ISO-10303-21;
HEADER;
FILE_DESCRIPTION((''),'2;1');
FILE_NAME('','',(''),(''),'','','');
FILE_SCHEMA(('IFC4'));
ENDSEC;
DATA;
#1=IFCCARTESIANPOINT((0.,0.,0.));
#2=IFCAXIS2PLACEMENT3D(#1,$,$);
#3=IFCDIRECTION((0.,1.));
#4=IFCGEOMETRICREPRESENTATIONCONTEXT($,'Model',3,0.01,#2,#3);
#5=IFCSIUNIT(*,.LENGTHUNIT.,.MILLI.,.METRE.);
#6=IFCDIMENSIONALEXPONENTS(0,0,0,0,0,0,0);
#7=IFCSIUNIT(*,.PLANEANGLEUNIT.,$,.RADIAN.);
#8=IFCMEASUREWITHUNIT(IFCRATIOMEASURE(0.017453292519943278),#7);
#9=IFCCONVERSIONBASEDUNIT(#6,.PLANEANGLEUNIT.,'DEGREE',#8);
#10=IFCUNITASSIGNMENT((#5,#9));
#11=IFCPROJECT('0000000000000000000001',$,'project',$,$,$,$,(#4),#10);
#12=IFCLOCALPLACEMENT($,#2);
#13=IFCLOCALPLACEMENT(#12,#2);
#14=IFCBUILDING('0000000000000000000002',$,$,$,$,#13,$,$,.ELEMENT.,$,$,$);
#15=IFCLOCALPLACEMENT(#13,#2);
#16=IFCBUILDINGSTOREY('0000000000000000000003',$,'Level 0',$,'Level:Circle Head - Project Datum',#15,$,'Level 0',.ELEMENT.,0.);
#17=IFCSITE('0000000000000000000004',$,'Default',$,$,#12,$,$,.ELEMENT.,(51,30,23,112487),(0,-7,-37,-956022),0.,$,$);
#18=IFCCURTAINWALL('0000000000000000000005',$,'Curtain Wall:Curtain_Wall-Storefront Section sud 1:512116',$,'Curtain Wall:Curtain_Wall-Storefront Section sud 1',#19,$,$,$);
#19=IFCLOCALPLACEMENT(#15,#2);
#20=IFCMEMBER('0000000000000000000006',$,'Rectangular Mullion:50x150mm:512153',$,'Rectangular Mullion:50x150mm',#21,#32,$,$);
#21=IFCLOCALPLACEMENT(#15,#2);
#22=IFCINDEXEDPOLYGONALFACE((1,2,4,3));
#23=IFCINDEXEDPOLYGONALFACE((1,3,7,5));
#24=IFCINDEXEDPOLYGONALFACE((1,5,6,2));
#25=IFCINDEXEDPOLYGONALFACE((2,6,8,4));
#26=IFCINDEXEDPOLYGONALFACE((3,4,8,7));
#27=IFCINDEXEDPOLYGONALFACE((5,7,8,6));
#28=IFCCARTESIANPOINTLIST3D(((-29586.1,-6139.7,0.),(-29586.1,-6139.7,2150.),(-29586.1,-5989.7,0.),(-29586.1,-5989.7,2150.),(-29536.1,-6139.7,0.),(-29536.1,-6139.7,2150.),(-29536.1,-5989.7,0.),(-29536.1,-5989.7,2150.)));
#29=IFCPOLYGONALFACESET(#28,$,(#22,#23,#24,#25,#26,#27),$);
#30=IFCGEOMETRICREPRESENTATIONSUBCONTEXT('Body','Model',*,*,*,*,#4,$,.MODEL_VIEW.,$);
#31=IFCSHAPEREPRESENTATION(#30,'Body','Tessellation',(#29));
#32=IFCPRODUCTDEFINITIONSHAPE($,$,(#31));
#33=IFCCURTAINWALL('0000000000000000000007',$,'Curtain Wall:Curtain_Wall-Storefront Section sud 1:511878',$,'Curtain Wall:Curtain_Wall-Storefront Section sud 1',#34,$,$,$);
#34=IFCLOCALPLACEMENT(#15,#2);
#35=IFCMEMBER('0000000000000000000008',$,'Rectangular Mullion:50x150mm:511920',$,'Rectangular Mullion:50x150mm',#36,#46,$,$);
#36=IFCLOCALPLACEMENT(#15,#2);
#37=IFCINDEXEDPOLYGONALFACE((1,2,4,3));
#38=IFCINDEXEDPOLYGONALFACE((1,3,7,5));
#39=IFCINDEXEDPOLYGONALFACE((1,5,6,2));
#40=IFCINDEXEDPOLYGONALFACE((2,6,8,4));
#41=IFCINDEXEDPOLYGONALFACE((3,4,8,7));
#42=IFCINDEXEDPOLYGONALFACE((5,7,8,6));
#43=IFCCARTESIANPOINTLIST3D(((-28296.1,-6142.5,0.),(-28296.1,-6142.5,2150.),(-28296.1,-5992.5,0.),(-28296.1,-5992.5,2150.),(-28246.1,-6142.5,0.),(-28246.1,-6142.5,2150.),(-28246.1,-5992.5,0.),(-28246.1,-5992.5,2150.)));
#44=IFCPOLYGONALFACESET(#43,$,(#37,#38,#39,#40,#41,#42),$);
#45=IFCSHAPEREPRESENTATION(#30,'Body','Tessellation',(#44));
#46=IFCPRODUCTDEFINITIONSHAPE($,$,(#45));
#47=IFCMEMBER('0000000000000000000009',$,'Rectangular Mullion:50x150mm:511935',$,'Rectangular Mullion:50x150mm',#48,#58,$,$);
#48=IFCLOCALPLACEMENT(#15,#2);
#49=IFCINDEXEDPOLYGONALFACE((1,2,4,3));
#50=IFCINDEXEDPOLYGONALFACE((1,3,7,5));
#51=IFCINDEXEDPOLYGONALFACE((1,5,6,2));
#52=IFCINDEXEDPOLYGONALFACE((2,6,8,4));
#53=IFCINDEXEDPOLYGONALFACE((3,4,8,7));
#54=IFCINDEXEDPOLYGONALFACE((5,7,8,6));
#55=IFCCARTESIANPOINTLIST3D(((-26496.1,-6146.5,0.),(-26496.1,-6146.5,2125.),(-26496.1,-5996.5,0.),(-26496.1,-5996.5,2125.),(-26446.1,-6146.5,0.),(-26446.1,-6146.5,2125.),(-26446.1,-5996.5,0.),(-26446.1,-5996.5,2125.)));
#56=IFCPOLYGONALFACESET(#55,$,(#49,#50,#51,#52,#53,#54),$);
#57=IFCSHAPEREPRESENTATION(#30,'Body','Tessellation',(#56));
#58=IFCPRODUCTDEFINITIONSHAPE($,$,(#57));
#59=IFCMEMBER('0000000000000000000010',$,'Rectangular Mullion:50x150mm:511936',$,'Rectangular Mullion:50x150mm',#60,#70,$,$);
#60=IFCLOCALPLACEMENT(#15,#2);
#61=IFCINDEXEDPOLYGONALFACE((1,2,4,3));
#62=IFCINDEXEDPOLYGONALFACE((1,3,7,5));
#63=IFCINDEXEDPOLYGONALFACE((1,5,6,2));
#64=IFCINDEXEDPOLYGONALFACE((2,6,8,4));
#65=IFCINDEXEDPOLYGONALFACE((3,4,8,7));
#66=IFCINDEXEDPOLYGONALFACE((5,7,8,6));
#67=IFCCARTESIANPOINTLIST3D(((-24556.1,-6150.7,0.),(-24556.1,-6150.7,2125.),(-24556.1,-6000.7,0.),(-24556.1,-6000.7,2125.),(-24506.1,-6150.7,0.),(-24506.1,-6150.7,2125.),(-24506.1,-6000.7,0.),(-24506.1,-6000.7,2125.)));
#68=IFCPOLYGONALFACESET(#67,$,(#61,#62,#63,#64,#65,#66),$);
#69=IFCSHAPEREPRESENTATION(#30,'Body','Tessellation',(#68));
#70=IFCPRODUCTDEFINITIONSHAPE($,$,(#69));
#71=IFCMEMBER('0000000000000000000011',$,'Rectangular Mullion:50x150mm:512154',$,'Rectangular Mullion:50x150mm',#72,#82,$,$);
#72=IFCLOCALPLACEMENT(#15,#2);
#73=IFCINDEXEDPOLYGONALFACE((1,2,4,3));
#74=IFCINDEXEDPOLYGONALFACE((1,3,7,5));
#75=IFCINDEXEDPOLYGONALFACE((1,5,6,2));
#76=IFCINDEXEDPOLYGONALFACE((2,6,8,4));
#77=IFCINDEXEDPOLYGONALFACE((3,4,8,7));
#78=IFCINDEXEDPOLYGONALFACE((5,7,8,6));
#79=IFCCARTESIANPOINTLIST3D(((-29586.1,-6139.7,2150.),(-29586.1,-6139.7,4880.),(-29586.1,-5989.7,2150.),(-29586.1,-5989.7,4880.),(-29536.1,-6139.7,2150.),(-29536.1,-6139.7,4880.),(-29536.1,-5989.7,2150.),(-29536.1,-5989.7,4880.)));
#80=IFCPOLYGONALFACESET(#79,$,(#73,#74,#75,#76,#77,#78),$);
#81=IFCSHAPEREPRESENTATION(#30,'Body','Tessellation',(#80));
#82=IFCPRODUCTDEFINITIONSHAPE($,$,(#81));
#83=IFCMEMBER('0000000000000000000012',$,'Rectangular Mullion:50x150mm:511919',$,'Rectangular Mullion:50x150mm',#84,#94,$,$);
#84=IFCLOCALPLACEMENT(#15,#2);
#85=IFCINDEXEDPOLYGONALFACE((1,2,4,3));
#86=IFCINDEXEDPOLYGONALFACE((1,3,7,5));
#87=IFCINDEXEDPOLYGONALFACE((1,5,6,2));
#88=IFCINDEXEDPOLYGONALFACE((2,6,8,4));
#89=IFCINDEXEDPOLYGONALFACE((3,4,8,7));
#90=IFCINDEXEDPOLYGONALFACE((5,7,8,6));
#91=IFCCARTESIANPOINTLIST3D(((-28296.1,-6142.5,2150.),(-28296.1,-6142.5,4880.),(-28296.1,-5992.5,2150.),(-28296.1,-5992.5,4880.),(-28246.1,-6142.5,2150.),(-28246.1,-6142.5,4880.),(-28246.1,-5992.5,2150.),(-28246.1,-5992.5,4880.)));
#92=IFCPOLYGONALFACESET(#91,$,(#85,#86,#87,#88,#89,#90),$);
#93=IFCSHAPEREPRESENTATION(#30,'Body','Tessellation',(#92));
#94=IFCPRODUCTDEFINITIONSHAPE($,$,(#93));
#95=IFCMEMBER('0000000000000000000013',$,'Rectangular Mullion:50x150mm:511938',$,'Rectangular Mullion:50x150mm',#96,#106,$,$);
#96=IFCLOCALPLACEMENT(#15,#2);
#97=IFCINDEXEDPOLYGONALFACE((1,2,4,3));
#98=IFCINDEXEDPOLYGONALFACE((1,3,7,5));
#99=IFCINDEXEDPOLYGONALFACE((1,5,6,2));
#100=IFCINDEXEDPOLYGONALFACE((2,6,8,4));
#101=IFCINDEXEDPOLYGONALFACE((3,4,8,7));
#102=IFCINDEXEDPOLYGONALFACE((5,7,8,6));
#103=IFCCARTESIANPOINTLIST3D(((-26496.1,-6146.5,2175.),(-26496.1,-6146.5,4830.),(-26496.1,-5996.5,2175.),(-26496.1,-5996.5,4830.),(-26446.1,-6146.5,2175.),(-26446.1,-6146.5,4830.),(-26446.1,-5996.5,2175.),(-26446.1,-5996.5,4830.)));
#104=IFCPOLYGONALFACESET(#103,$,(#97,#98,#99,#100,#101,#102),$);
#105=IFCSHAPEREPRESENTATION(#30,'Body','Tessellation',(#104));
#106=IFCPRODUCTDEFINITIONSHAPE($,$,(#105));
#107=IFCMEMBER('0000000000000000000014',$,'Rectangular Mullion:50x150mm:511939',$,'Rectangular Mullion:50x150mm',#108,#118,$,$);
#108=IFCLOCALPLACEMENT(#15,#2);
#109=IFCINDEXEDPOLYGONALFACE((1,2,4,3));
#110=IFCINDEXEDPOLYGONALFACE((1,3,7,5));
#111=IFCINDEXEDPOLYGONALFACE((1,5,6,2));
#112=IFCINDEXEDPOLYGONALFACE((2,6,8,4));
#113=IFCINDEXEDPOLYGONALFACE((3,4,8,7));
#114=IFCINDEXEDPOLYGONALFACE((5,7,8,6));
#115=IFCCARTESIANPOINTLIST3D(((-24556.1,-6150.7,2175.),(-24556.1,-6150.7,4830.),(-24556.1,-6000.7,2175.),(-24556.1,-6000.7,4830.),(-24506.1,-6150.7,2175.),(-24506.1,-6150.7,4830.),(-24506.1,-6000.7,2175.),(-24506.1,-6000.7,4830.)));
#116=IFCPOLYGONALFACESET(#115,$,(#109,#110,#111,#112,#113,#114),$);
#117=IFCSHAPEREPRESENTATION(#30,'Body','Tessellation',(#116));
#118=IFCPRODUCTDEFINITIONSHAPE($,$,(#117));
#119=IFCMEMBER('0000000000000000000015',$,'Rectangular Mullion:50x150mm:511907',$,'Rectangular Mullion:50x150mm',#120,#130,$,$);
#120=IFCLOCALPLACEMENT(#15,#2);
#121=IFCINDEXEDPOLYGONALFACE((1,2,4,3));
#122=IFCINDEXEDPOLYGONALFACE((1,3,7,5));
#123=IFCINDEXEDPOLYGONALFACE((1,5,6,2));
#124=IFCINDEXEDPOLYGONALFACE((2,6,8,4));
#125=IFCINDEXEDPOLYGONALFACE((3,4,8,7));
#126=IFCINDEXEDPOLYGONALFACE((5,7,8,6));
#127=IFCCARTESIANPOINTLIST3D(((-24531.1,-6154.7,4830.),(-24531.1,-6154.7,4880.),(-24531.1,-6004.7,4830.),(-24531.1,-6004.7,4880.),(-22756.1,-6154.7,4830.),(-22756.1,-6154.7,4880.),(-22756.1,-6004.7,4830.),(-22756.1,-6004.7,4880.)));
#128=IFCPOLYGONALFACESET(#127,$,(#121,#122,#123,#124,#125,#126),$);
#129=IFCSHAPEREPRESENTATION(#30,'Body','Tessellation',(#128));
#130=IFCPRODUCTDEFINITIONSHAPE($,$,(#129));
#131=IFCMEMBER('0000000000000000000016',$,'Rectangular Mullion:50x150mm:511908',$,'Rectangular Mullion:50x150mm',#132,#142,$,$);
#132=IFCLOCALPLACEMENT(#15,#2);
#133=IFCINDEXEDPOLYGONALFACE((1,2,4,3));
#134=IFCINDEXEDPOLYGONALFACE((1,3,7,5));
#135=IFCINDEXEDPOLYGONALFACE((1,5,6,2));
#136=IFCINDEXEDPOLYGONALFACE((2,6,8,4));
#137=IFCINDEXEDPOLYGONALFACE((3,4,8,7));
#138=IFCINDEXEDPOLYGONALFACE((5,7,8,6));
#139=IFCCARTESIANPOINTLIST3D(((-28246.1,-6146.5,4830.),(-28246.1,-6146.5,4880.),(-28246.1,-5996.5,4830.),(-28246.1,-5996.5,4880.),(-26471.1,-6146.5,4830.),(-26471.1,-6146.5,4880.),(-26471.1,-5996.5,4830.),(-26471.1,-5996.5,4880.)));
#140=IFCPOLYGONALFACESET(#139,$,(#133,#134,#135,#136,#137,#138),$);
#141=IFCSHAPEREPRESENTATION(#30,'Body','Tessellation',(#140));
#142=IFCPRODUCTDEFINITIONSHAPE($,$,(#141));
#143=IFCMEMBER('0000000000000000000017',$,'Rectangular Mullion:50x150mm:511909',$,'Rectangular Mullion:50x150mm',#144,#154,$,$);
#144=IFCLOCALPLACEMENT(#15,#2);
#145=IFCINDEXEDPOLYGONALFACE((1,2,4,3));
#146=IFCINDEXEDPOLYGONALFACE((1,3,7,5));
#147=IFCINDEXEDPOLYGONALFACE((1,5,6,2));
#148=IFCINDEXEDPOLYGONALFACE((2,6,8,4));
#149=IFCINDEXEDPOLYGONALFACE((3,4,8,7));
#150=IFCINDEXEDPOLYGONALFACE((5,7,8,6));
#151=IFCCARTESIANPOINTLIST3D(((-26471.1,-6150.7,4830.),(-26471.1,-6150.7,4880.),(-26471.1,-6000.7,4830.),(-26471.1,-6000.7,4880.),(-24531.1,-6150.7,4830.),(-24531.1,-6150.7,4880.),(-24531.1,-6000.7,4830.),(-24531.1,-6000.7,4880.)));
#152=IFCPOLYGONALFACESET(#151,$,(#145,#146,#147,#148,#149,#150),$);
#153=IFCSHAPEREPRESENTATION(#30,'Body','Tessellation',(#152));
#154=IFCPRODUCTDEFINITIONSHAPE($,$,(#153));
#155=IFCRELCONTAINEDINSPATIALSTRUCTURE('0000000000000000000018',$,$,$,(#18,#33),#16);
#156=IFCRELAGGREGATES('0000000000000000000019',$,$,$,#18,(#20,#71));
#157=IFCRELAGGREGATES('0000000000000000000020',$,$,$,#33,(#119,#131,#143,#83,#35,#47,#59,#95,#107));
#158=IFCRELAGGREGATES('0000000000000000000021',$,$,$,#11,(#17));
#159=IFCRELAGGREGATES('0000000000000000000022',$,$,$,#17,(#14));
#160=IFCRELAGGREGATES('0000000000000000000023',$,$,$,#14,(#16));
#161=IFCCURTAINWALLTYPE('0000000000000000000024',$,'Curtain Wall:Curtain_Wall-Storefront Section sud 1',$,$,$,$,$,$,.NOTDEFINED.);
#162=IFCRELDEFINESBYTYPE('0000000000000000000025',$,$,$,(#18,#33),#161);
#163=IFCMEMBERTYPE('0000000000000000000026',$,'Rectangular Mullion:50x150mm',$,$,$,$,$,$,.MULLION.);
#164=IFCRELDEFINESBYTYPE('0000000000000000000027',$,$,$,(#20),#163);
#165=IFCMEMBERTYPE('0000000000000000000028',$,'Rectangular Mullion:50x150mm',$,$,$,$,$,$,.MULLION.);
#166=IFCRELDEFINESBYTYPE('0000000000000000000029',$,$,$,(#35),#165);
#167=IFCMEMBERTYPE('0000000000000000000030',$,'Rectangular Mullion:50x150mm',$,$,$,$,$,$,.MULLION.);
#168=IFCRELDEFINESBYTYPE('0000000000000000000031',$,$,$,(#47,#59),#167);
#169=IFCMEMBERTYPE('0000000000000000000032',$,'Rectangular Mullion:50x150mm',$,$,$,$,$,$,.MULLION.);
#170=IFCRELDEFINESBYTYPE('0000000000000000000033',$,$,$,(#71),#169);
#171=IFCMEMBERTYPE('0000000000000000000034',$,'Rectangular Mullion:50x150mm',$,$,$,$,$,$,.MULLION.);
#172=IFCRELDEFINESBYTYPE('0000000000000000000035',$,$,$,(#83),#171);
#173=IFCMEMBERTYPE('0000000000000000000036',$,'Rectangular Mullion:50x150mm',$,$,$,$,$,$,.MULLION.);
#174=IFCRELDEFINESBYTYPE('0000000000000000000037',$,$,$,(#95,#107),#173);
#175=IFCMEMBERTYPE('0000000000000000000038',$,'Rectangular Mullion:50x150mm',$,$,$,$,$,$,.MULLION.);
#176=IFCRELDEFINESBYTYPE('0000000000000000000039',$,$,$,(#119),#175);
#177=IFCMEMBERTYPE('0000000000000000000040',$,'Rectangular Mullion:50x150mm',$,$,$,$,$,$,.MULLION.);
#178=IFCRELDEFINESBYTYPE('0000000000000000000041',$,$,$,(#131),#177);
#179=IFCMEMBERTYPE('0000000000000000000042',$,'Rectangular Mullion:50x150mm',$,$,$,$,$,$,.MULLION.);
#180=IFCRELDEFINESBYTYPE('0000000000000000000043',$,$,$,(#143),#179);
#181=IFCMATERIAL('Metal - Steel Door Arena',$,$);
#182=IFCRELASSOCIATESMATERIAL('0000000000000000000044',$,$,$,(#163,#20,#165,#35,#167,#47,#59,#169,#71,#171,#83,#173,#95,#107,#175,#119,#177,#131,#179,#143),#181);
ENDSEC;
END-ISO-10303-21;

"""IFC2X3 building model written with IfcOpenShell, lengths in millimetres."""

from ifc_helpers import new_model, entity, si_unit, converted_unit, direction, frame, origin, origin_2d_with_axis, place, context, subcontext, project, spatial, rectangle, extrude, source, transform, mapped, material, type_object, type_shapes, element, aggregate, save


model = new_model("IFC2X3")

# Units and contexts
model_context = context("Model", 3, precision=0.01, world=origin(), true_north=direction((0.0, 1.0)))
body_context = subcontext(model_context, "Body", "Model", "MODEL_VIEW")
ifc_project = project(units=[si_unit("LENGTHUNIT", "METRE", prefix="MILLI"), converted_unit("PLANEANGLEUNIT", "DEGREE", entity("IfcRatioMeasure", 0.017453292519943278), si_unit("PLANEANGLEUNIT", "RADIAN"), dimensions=[0, 0, 0, 0, 0, 0, 0])], contexts=[model_context])

# Site, building, storey
site_placement = place(None, origin())
site = spatial("IfcSite", under=ifc_project, at=site_placement, Name="Default", CompositionType="ELEMENT", RefLatitude=(51, 30, 23, 112487), RefLongitude=(0, -7, -37, -956022), RefElevation=0.0)
building_placement = place(site_placement, origin())
building = spatial("IfcBuilding", under=site, at=building_placement, CompositionType="ELEMENT")
storey_placement = place(building_placement, origin())
storey = spatial("IfcBuildingStorey", under=building, at=storey_placement, Name="Level 0", ObjectType="Level:Circle Head - Project Datum", LongName="Level 0", CompositionType="ELEMENT", Elevation=0.0)

# Curtain wall, member
curtain_wall_type = type_object("IfcCurtainWallType", Name="Curtain Wall:Curtain_Wall-Storefront Section sud 1", PredefinedType="NOTDEFINED")
curtain_wall_1_placement = place(storey_placement, origin())
curtain_wall_1 = element("IfcCurtainWall", 1, at=curtain_wall_1_placement, inside=storey, type_object=curtain_wall_type, Name="Curtain Wall:Curtain_Wall-Storefront Section sud 1:512116", ObjectType="Curtain Wall:Curtain_Wall-Storefront Section sud 1")
ifc_material_1 = material(Name="Metal - Steel Door Arena")
member_type_1 = type_object("IfcMemberType", Name="Rectangular Mullion:50x150mm", PredefinedType="MULLION", material=ifc_material_1)
shared_shape_1 = source(origin(), body_context, "Body", "SweptSolid", [
    extrude(rectangle(XDim=150.0, YDim=50.0, at=origin_2d_with_axis()), frame((-25.0, 0.0, -2150.0), z_axis=(0.0, 0.0, 1.0), x_axis=(0.0, -1.0, 0.0)), (0.0, 0.0, 1.0), 2150.0),
])
type_shapes(member_type_1, [shared_shape_1])
member_1_placement = place(curtain_wall_1_placement, frame((-29536.1, -6064.7, 0.0), z_axis=(0.0, 0.0, -1.0), x_axis=(1.0, 0.0, 0.0)))
member_1 = element("IfcMember", 2, at=member_1_placement, type_object=member_type_1, material=ifc_material_1, Name="Rectangular Mullion:50x150mm:512153", ObjectType="Rectangular Mullion:50x150mm", context=body_context, shape_type="MappedRepresentation", body=[
    mapped(shared_shape_1, transform((0.0, 0.0, 0.0), scale=1.0)),
])

# Curtain wall, members
curtain_wall_2_placement = place(storey_placement, origin())
curtain_wall_2 = element("IfcCurtainWall", 3, at=curtain_wall_2_placement, inside=storey, type_object=curtain_wall_type, Name="Curtain Wall:Curtain_Wall-Storefront Section sud 1:511878", ObjectType="Curtain Wall:Curtain_Wall-Storefront Section sud 1")
member_type_2 = type_object("IfcMemberType", Name="Rectangular Mullion:50x150mm", PredefinedType="MULLION", material=ifc_material_1)
shared_shape_2 = source(origin(), body_context, "Body", "SweptSolid", [
    extrude(rectangle(XDim=150.0, YDim=50.0, at=origin_2d_with_axis()), frame((-25.0, 0.0, -2150.0), z_axis=(0.0, 0.0, 1.0), x_axis=(0.0, -1.0, 0.0)), (0.0, 0.0, 1.0), 2150.0),
])
type_shapes(member_type_2, [shared_shape_2])
member_2_placement = place(curtain_wall_2_placement, frame((-28296.1, -6067.5, 2150.0), z_axis=(0.0, 0.0, 1.0), x_axis=(-1.0, 0.0, 0.0)))
member_2 = element("IfcMember", 4, at=member_2_placement, type_object=member_type_2, material=ifc_material_1, Name="Rectangular Mullion:50x150mm:511920", ObjectType="Rectangular Mullion:50x150mm", context=body_context, shape_type="MappedRepresentation", body=[
    mapped(shared_shape_2, transform((0.0, 0.0, 0.0), scale=1.0)),
])
member_type_3 = type_object("IfcMemberType", Name="Rectangular Mullion:50x150mm", PredefinedType="MULLION", material=ifc_material_1)
shared_shape_3 = source(origin(), body_context, "Body", "SweptSolid", [
    extrude(rectangle(XDim=150.0, YDim=50.0, at=origin_2d_with_axis()), frame((0.0, 0.0, -2125.0), z_axis=(0.0, 0.0, 1.0), x_axis=(0.0, -1.0, 0.0)), (0.0, 0.0, 1.0), 2125.0),
])
type_shapes(member_type_3, [shared_shape_3])
member_3_placement = place(curtain_wall_2_placement, frame((-26471.1, -6071.5, 0.0), z_axis=(0.0, 0.0, -1.0), x_axis=(1.0, 0.0, 0.0)))
member_3 = element("IfcMember", 5, at=member_3_placement, type_object=member_type_3, material=ifc_material_1, Name="Rectangular Mullion:50x150mm:511935", ObjectType="Rectangular Mullion:50x150mm", context=body_context, shape_type="MappedRepresentation", body=[
    mapped(shared_shape_3, transform((0.0, 0.0, 0.0), scale=1.0)),
])
member_4_placement = place(curtain_wall_2_placement, frame((-24531.1, -6075.7, 0.0), z_axis=(0.0, 0.0, -1.0), x_axis=(1.0, 0.0, 0.0)))
member_4 = element("IfcMember", 6, at=member_4_placement, type_object=member_type_3, material=ifc_material_1, Name="Rectangular Mullion:50x150mm:511936", ObjectType="Rectangular Mullion:50x150mm", context=body_context, shape_type="MappedRepresentation", body=[
    mapped(shared_shape_3, transform((0.0, 0.0, 0.0), scale=1.0)),
])

# Members
member_type_4 = type_object("IfcMemberType", Name="Rectangular Mullion:50x150mm", PredefinedType="MULLION", material=ifc_material_1)
shared_shape_4 = source(origin(), body_context, "Body", "SweptSolid", [
    extrude(rectangle(XDim=150.0, YDim=50.0, at=origin_2d_with_axis()), frame((-25.0, 0.0, -2730.0), z_axis=(0.0, 0.0, 1.0), x_axis=(0.0, -1.0, 0.0)), (0.0, 0.0, 1.0), 2730.0),
])
type_shapes(member_type_4, [shared_shape_4])
member_5_placement = place(curtain_wall_1_placement, frame((-29536.1, -6064.7, 2150.0), z_axis=(0.0, 0.0, -1.0), x_axis=(1.0, 0.0, 0.0)))
member_5 = element("IfcMember", 7, at=member_5_placement, type_object=member_type_4, material=ifc_material_1, Name="Rectangular Mullion:50x150mm:512154", ObjectType="Rectangular Mullion:50x150mm", context=body_context, shape_type="MappedRepresentation", body=[
    mapped(shared_shape_4, transform((0.0, 0.0, 0.0), scale=1.0)),
])
aggregate(curtain_wall_1, [member_1, member_5])
member_type_5 = type_object("IfcMemberType", Name="Rectangular Mullion:50x150mm", PredefinedType="MULLION", material=ifc_material_1)
shared_shape_5 = source(origin(), body_context, "Body", "SweptSolid", [
    extrude(rectangle(XDim=150.0, YDim=50.0, at=origin_2d_with_axis()), frame((-25.0, 0.0, -2730.0), z_axis=(0.0, 0.0, 1.0), x_axis=(0.0, -1.0, 0.0)), (0.0, 0.0, 1.0), 2730.0),
])
type_shapes(member_type_5, [shared_shape_5])
member_6_placement = place(curtain_wall_2_placement, frame((-28296.1, -6067.5, 4880.0), z_axis=(0.0, 0.0, 1.0), x_axis=(-1.0, 0.0, 0.0)))
member_6 = element("IfcMember", 8, at=member_6_placement, type_object=member_type_5, material=ifc_material_1, Name="Rectangular Mullion:50x150mm:511919", ObjectType="Rectangular Mullion:50x150mm", context=body_context, shape_type="MappedRepresentation", body=[
    mapped(shared_shape_5, transform((0.0, 0.0, 0.0), scale=1.0)),
])
member_type_6 = type_object("IfcMemberType", Name="Rectangular Mullion:50x150mm", PredefinedType="MULLION", material=ifc_material_1)
shared_shape_6 = source(origin(), body_context, "Body", "SweptSolid", [
    extrude(rectangle(XDim=150.0, YDim=50.0, at=origin_2d_with_axis()), frame((0.0, 0.0, -2655.0), z_axis=(0.0, 0.0, 1.0), x_axis=(0.0, -1.0, 0.0)), (0.0, 0.0, 1.0), 2655.0),
])
type_shapes(member_type_6, [shared_shape_6])
member_7_placement = place(curtain_wall_2_placement, frame((-26471.1, -6071.5, 2175.0), z_axis=(0.0, 0.0, -1.0), x_axis=(1.0, 0.0, 0.0)))
member_7 = element("IfcMember", 9, at=member_7_placement, type_object=member_type_6, material=ifc_material_1, Name="Rectangular Mullion:50x150mm:511938", ObjectType="Rectangular Mullion:50x150mm", context=body_context, shape_type="MappedRepresentation", body=[
    mapped(shared_shape_6, transform((0.0, 0.0, 0.0), scale=1.0)),
])
member_8_placement = place(curtain_wall_2_placement, frame((-24531.1, -6075.7, 2175.0), z_axis=(0.0, 0.0, -1.0), x_axis=(1.0, 0.0, 0.0)))
member_8 = element("IfcMember", 10, at=member_8_placement, type_object=member_type_6, material=ifc_material_1, Name="Rectangular Mullion:50x150mm:511939", ObjectType="Rectangular Mullion:50x150mm", context=body_context, shape_type="MappedRepresentation", body=[
    mapped(shared_shape_6, transform((0.0, 0.0, 0.0), scale=1.0)),
])
member_type_7 = type_object("IfcMemberType", Name="Rectangular Mullion:50x150mm", PredefinedType="MULLION", material=ifc_material_1)
shared_shape_7 = source(origin(), body_context, "Body", "SweptSolid", [
    extrude(rectangle(XDim=150.0, YDim=50.0, at=origin_2d_with_axis()), frame((-25.0, 0.0, -1775.0), z_axis=(0.0, 0.0, 1.0), x_axis=(0.0, -1.0, 0.0)), (0.0, 0.0, 1.0), 1775.0),
])
type_shapes(member_type_7, [shared_shape_7])
member_9_placement = place(curtain_wall_2_placement, frame((-22756.1, -6079.7, 4880.0), z_axis=(1.0, 0.0, 0.0), x_axis=(0.0, 0.0, 1.0)))
member_9 = element("IfcMember", 11, at=member_9_placement, type_object=member_type_7, material=ifc_material_1, Name="Rectangular Mullion:50x150mm:511907", ObjectType="Rectangular Mullion:50x150mm", context=body_context, shape_type="MappedRepresentation", body=[
    mapped(shared_shape_7, transform((0.0, 0.0, 0.0), scale=1.0)),
])
member_type_8 = type_object("IfcMemberType", Name="Rectangular Mullion:50x150mm", PredefinedType="MULLION", material=ifc_material_1)
shared_shape_8 = source(origin(), body_context, "Body", "SweptSolid", [
    extrude(rectangle(XDim=150.0, YDim=50.0, at=origin_2d_with_axis()), frame((-25.0, 0.0, -1775.0), z_axis=(0.0, 0.0, 1.0), x_axis=(0.0, -1.0, 0.0)), (0.0, 0.0, 1.0), 1775.0),
])
type_shapes(member_type_8, [shared_shape_8])
member_10_placement = place(curtain_wall_2_placement, frame((-26471.1, -6071.5, 4880.0), z_axis=(1.0, 0.0, 0.0), x_axis=(0.0, 0.0, 1.0)))
member_10 = element("IfcMember", 12, at=member_10_placement, type_object=member_type_8, material=ifc_material_1, Name="Rectangular Mullion:50x150mm:511908", ObjectType="Rectangular Mullion:50x150mm", context=body_context, shape_type="MappedRepresentation", body=[
    mapped(shared_shape_8, transform((0.0, 0.0, 0.0), scale=1.0)),
])
member_type_9 = type_object("IfcMemberType", Name="Rectangular Mullion:50x150mm", PredefinedType="MULLION", material=ifc_material_1)
shared_shape_9 = source(origin(), body_context, "Body", "SweptSolid", [
    extrude(rectangle(XDim=150.0, YDim=50.0, at=origin_2d_with_axis()), frame((-25.0, 0.0, -1940.0), z_axis=(0.0, 0.0, 1.0), x_axis=(0.0, -1.0, 0.0)), (0.0, 0.0, 1.0), 1940.0),
])
type_shapes(member_type_9, [shared_shape_9])
member_11_placement = place(curtain_wall_2_placement, frame((-24531.1, -6075.7, 4880.0), z_axis=(1.0, 0.0, 0.0), x_axis=(0.0, 0.0, 1.0)))
member_11 = element("IfcMember", 13, at=member_11_placement, type_object=member_type_9, material=ifc_material_1, Name="Rectangular Mullion:50x150mm:511909", ObjectType="Rectangular Mullion:50x150mm", context=body_context, shape_type="MappedRepresentation", body=[
    mapped(shared_shape_9, transform((0.0, 0.0, 0.0), scale=1.0)),
])

aggregate(curtain_wall_2, [member_9, member_10, member_11, member_6, member_2, member_3, member_4, member_7, member_8])

save(model, "model.ifc")
